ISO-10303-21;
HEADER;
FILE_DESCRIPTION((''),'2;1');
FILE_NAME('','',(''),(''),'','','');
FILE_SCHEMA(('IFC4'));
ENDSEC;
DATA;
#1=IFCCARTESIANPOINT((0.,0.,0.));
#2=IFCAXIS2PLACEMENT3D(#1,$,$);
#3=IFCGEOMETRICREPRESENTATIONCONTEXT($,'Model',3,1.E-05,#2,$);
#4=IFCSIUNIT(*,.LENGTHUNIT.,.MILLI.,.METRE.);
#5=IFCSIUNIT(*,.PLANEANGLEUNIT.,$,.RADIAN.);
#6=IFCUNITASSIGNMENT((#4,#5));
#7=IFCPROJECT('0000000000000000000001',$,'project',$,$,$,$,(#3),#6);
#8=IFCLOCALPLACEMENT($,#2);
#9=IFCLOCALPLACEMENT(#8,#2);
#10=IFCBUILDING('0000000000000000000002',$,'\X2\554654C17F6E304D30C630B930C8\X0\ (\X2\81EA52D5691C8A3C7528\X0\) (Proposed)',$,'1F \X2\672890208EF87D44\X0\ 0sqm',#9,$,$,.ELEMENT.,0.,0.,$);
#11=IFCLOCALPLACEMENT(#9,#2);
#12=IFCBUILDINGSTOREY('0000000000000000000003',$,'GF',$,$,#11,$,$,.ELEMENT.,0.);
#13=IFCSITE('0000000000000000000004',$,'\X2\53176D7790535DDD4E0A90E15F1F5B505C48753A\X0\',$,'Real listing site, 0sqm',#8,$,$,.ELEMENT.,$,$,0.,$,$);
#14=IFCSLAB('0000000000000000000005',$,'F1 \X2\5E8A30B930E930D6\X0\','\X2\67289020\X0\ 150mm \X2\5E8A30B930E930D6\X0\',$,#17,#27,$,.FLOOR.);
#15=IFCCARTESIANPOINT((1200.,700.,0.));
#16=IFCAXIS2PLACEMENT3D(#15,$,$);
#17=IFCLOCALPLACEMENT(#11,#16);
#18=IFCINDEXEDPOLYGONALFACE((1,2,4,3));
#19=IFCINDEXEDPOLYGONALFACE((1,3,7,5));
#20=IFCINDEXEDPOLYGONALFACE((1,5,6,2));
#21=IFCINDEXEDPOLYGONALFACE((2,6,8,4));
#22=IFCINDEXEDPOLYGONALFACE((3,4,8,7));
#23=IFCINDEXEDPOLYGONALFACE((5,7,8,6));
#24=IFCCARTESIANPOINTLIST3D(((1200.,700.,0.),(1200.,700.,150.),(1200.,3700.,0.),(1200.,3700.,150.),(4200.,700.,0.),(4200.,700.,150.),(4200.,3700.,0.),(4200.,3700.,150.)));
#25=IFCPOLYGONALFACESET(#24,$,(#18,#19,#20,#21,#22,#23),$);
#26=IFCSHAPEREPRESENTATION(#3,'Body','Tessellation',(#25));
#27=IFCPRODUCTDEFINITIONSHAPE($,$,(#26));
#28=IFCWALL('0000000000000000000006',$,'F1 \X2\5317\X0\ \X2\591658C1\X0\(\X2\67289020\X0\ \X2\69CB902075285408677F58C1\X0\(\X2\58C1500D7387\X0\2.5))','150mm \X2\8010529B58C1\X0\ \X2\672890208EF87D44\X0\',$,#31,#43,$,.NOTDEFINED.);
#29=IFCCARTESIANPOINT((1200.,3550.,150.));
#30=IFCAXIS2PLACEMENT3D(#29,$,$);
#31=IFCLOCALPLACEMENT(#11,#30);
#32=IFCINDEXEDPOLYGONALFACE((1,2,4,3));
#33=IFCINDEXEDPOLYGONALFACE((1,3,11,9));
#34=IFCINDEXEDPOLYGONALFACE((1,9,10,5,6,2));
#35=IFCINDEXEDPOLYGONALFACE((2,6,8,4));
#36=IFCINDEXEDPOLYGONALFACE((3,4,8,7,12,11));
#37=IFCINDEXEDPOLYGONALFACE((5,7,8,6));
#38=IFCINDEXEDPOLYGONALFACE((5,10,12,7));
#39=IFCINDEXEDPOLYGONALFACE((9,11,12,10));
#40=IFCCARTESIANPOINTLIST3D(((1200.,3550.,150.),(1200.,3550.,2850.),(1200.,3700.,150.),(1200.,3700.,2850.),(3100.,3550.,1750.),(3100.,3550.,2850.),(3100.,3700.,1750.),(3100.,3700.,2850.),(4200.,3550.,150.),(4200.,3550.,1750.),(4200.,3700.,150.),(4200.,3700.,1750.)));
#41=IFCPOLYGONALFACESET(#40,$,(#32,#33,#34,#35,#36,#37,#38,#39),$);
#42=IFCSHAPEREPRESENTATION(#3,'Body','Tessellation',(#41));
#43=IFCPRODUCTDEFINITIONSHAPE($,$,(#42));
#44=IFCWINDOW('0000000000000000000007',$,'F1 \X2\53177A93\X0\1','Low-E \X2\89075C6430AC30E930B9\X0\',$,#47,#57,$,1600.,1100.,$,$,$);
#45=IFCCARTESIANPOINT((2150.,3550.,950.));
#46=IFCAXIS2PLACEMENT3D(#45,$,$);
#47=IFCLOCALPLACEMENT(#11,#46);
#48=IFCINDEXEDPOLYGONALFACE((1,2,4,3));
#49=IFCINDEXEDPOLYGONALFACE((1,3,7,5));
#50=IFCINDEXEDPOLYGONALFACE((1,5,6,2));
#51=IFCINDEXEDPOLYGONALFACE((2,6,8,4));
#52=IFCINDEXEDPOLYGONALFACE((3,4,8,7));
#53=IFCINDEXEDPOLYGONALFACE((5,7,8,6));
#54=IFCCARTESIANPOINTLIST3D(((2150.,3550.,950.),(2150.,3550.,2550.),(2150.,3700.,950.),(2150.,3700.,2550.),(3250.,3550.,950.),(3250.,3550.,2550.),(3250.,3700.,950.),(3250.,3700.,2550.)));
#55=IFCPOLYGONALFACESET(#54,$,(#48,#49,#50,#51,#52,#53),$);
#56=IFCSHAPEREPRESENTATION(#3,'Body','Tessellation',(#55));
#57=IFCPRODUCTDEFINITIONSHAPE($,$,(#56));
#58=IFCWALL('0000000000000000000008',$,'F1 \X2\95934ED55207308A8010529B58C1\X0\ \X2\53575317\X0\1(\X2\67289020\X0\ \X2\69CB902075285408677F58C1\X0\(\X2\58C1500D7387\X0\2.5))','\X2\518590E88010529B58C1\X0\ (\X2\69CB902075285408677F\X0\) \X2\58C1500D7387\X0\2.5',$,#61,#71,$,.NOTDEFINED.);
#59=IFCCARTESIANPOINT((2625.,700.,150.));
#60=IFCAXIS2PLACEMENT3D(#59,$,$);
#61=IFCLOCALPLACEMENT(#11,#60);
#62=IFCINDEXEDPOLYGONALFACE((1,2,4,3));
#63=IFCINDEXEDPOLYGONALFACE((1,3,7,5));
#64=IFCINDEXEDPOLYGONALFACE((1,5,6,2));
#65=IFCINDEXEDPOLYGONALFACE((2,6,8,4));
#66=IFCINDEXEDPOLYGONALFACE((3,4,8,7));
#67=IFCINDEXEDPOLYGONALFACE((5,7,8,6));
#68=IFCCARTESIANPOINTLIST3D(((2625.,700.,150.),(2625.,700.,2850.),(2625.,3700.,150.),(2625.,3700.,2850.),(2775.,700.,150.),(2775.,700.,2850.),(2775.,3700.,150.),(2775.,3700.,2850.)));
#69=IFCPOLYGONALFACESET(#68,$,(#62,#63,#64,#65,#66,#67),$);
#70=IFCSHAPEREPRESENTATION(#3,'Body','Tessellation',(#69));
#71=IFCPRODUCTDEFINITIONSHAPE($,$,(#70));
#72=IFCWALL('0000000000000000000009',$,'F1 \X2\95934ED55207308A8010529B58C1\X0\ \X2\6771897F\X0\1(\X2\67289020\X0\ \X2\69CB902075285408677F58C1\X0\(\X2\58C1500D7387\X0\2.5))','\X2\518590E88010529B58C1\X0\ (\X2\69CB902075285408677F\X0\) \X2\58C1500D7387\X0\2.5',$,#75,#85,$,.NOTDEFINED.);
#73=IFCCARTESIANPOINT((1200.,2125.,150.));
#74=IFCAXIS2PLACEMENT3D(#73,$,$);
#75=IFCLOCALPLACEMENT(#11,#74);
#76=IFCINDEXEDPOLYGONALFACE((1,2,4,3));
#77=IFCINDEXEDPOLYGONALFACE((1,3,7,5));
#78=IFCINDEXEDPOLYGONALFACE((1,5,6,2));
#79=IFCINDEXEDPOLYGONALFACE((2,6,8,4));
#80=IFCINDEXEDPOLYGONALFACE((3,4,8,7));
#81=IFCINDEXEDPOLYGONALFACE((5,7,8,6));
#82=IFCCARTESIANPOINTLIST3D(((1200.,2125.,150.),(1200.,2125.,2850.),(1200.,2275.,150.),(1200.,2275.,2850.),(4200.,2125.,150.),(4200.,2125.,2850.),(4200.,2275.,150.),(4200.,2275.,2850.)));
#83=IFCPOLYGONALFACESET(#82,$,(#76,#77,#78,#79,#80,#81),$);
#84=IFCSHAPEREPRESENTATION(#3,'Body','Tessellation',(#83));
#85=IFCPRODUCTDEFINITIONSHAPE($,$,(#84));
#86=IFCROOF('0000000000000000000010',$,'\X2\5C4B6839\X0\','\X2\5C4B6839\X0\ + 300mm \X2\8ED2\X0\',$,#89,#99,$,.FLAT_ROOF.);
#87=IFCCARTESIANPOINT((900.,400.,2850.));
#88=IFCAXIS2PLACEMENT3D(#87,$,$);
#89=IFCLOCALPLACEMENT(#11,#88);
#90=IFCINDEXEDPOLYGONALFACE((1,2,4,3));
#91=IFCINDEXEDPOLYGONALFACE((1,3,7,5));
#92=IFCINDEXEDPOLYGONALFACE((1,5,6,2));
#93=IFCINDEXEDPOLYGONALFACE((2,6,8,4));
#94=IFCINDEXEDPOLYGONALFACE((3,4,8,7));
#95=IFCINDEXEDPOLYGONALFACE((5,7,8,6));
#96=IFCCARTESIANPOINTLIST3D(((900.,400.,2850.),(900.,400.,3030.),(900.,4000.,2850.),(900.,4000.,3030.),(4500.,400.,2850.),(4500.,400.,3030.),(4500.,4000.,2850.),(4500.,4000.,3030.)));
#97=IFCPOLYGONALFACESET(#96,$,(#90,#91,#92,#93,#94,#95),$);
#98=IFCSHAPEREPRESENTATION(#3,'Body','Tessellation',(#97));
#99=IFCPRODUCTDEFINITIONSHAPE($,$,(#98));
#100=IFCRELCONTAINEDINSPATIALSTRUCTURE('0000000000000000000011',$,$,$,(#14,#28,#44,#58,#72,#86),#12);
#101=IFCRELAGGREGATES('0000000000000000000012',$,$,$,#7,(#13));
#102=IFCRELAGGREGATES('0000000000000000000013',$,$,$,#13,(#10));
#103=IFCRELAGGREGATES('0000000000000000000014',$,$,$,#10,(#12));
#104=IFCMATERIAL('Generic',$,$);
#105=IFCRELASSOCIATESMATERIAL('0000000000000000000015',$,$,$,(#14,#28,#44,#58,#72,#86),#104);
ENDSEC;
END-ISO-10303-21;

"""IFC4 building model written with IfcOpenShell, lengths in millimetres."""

from ifc_helpers import new_model, si_unit, frame, frame_2d, origin, place, context, project, spatial, rectangle, extrude, material, element, fill, save


model = new_model("IFC4")

# Units and contexts
model_context = context("Model", 3, precision=1e-05, world=origin())
ifc_project = project(units=[si_unit("LENGTHUNIT", "METRE", prefix="MILLI"), si_unit("PLANEANGLEUNIT", "RADIAN")], contexts=[model_context])

# Site, building, storey
site_placement = place(None, origin())
site = spatial("IfcSite", under=ifc_project, at=site_placement, Name="北海道川上郡弟子屈町", ObjectType="Real listing site, 0sqm", CompositionType="ELEMENT", RefElevation=0.0)
building_placement = place(site_placement, origin())
building = spatial("IfcBuilding", under=site, at=building_placement, Name="商品置きテスト (自動検証用) (Proposed)", ObjectType="1F 木造軸組 0sqm", CompositionType="ELEMENT", ElevationOfRefHeight=0.0, ElevationOfTerrain=0.0)
storey_placement = place(building_placement, origin())
storey = spatial("IfcBuildingStorey", under=building, at=storey_placement, Name="GF", CompositionType="ELEMENT", Elevation=0.0)

# Slab
ifc_material_1 = material(Name="Generic")
slab_placement = place(storey_placement, frame((1200.0, 700.0, 0.0)))
element("IfcSlab", 1, at=slab_placement, inside=storey, material=ifc_material_1, Name="F1 床スラブ", Description="木造 150mm 床スラブ", PredefinedType="FLOOR", context=model_context, shape_type="SweptSolid", body=[
    extrude(rectangle(XDim=3000.0, YDim=3000.0, at=frame_2d((1500.0, 1500.0))), frame((1200.0, 700.0, 0.0)), (0.0, 0.0, 1.0), 150.0),
])

# Wall, opening, window
wall_1_placement = place(storey_placement, frame((1200.0, 3550.0, 150.0)))
wall_1 = element("IfcWall", 2, at=wall_1_placement, inside=storey, material=ifc_material_1, Name="F1 北 外壁(木造 構造用合板壁(壁倍率2.5))", Description="150mm 耐力壁 木造軸組", PredefinedType="NOTDEFINED", context=model_context, shape_type="SweptSolid", body=[
    extrude(rectangle(XDim=3000.0, YDim=150.0, at=frame_2d((1500.0, 75.0))), frame((1200.0, 3550.0, 150.0)), (0.0, 0.0, 1.0), 2700.0),
])
opening_1_placement = place(storey_placement, frame((2150.0, 3550.0, 950.0)))
opening_1 = element("IfcOpeningElement", 3, at=opening_1_placement, cuts=wall_1, PredefinedType="NOTDEFINED", context=model_context, shape_type="SweptSolid", body=[
    extrude(rectangle(XDim=1100.0, YDim=150.0, at=frame_2d((550.0, 75.0))), frame((2150.0, 3550.0, 950.0)), (0.0, 0.0, 1.0), 1600.0),
])
window_1_placement = place(storey_placement, frame((2150.0, 3550.0, 950.0)))
window_1 = element("IfcWindow", 4, at=window_1_placement, inside=storey, material=ifc_material_1, Name="F1 北窓1", Description="Low-E 複層ガラス", OverallHeight=1600.0, OverallWidth=1100.0, context=model_context, shape_type="SweptSolid", body=[
    extrude(rectangle(XDim=1100.0, YDim=150.0, at=frame_2d((550.0, 75.0))), frame((2150.0, 3550.0, 950.0)), (0.0, 0.0, 1.0), 1600.0),
])
fill(opening_1, window_1)

# Walls
wall_2_placement = place(storey_placement, frame((2625.0, 700.0, 150.0)))
element("IfcWall", 5, at=wall_2_placement, inside=storey, material=ifc_material_1, Name="F1 間仕切り耐力壁 南北1(木造 構造用合板壁(壁倍率2.5))", Description="内部耐力壁 (構造用合板) 壁倍率2.5", PredefinedType="NOTDEFINED", context=model_context, shape_type="SweptSolid", body=[
    extrude(rectangle(XDim=150.0, YDim=3000.0, at=frame_2d((75.0, 1500.0))), frame((2625.0, 700.0, 150.0)), (0.0, 0.0, 1.0), 2700.0),
])
wall_3_placement = place(storey_placement, frame((1200.0, 2125.0, 150.0)))
element("IfcWall", 6, at=wall_3_placement, inside=storey, material=ifc_material_1, Name="F1 間仕切り耐力壁 東西1(木造 構造用合板壁(壁倍率2.5))", Description="内部耐力壁 (構造用合板) 壁倍率2.5", PredefinedType="NOTDEFINED", context=model_context, shape_type="SweptSolid", body=[
    extrude(rectangle(XDim=3000.0, YDim=150.0, at=frame_2d((1500.0, 75.0))), frame((1200.0, 2125.0, 150.0)), (0.0, 0.0, 1.0), 2700.0),
])

# Roof
roof_placement = place(storey_placement, frame((900.0, 400.0, 2850.0)))
element("IfcRoof", 7, at=roof_placement, inside=storey, material=ifc_material_1, Name="屋根", Description="屋根 + 300mm 軒", PredefinedType="FLAT_ROOF", context=model_context, shape_type="SweptSolid", body=[
    extrude(rectangle(XDim=3600.0, YDim=3600.0, at=frame_2d((1800.0, 1800.0))), frame((900.0, 400.0, 2850.0)), (0.0, 0.0, 1.0), 180.0),
])

save(model, "model.ifc")
